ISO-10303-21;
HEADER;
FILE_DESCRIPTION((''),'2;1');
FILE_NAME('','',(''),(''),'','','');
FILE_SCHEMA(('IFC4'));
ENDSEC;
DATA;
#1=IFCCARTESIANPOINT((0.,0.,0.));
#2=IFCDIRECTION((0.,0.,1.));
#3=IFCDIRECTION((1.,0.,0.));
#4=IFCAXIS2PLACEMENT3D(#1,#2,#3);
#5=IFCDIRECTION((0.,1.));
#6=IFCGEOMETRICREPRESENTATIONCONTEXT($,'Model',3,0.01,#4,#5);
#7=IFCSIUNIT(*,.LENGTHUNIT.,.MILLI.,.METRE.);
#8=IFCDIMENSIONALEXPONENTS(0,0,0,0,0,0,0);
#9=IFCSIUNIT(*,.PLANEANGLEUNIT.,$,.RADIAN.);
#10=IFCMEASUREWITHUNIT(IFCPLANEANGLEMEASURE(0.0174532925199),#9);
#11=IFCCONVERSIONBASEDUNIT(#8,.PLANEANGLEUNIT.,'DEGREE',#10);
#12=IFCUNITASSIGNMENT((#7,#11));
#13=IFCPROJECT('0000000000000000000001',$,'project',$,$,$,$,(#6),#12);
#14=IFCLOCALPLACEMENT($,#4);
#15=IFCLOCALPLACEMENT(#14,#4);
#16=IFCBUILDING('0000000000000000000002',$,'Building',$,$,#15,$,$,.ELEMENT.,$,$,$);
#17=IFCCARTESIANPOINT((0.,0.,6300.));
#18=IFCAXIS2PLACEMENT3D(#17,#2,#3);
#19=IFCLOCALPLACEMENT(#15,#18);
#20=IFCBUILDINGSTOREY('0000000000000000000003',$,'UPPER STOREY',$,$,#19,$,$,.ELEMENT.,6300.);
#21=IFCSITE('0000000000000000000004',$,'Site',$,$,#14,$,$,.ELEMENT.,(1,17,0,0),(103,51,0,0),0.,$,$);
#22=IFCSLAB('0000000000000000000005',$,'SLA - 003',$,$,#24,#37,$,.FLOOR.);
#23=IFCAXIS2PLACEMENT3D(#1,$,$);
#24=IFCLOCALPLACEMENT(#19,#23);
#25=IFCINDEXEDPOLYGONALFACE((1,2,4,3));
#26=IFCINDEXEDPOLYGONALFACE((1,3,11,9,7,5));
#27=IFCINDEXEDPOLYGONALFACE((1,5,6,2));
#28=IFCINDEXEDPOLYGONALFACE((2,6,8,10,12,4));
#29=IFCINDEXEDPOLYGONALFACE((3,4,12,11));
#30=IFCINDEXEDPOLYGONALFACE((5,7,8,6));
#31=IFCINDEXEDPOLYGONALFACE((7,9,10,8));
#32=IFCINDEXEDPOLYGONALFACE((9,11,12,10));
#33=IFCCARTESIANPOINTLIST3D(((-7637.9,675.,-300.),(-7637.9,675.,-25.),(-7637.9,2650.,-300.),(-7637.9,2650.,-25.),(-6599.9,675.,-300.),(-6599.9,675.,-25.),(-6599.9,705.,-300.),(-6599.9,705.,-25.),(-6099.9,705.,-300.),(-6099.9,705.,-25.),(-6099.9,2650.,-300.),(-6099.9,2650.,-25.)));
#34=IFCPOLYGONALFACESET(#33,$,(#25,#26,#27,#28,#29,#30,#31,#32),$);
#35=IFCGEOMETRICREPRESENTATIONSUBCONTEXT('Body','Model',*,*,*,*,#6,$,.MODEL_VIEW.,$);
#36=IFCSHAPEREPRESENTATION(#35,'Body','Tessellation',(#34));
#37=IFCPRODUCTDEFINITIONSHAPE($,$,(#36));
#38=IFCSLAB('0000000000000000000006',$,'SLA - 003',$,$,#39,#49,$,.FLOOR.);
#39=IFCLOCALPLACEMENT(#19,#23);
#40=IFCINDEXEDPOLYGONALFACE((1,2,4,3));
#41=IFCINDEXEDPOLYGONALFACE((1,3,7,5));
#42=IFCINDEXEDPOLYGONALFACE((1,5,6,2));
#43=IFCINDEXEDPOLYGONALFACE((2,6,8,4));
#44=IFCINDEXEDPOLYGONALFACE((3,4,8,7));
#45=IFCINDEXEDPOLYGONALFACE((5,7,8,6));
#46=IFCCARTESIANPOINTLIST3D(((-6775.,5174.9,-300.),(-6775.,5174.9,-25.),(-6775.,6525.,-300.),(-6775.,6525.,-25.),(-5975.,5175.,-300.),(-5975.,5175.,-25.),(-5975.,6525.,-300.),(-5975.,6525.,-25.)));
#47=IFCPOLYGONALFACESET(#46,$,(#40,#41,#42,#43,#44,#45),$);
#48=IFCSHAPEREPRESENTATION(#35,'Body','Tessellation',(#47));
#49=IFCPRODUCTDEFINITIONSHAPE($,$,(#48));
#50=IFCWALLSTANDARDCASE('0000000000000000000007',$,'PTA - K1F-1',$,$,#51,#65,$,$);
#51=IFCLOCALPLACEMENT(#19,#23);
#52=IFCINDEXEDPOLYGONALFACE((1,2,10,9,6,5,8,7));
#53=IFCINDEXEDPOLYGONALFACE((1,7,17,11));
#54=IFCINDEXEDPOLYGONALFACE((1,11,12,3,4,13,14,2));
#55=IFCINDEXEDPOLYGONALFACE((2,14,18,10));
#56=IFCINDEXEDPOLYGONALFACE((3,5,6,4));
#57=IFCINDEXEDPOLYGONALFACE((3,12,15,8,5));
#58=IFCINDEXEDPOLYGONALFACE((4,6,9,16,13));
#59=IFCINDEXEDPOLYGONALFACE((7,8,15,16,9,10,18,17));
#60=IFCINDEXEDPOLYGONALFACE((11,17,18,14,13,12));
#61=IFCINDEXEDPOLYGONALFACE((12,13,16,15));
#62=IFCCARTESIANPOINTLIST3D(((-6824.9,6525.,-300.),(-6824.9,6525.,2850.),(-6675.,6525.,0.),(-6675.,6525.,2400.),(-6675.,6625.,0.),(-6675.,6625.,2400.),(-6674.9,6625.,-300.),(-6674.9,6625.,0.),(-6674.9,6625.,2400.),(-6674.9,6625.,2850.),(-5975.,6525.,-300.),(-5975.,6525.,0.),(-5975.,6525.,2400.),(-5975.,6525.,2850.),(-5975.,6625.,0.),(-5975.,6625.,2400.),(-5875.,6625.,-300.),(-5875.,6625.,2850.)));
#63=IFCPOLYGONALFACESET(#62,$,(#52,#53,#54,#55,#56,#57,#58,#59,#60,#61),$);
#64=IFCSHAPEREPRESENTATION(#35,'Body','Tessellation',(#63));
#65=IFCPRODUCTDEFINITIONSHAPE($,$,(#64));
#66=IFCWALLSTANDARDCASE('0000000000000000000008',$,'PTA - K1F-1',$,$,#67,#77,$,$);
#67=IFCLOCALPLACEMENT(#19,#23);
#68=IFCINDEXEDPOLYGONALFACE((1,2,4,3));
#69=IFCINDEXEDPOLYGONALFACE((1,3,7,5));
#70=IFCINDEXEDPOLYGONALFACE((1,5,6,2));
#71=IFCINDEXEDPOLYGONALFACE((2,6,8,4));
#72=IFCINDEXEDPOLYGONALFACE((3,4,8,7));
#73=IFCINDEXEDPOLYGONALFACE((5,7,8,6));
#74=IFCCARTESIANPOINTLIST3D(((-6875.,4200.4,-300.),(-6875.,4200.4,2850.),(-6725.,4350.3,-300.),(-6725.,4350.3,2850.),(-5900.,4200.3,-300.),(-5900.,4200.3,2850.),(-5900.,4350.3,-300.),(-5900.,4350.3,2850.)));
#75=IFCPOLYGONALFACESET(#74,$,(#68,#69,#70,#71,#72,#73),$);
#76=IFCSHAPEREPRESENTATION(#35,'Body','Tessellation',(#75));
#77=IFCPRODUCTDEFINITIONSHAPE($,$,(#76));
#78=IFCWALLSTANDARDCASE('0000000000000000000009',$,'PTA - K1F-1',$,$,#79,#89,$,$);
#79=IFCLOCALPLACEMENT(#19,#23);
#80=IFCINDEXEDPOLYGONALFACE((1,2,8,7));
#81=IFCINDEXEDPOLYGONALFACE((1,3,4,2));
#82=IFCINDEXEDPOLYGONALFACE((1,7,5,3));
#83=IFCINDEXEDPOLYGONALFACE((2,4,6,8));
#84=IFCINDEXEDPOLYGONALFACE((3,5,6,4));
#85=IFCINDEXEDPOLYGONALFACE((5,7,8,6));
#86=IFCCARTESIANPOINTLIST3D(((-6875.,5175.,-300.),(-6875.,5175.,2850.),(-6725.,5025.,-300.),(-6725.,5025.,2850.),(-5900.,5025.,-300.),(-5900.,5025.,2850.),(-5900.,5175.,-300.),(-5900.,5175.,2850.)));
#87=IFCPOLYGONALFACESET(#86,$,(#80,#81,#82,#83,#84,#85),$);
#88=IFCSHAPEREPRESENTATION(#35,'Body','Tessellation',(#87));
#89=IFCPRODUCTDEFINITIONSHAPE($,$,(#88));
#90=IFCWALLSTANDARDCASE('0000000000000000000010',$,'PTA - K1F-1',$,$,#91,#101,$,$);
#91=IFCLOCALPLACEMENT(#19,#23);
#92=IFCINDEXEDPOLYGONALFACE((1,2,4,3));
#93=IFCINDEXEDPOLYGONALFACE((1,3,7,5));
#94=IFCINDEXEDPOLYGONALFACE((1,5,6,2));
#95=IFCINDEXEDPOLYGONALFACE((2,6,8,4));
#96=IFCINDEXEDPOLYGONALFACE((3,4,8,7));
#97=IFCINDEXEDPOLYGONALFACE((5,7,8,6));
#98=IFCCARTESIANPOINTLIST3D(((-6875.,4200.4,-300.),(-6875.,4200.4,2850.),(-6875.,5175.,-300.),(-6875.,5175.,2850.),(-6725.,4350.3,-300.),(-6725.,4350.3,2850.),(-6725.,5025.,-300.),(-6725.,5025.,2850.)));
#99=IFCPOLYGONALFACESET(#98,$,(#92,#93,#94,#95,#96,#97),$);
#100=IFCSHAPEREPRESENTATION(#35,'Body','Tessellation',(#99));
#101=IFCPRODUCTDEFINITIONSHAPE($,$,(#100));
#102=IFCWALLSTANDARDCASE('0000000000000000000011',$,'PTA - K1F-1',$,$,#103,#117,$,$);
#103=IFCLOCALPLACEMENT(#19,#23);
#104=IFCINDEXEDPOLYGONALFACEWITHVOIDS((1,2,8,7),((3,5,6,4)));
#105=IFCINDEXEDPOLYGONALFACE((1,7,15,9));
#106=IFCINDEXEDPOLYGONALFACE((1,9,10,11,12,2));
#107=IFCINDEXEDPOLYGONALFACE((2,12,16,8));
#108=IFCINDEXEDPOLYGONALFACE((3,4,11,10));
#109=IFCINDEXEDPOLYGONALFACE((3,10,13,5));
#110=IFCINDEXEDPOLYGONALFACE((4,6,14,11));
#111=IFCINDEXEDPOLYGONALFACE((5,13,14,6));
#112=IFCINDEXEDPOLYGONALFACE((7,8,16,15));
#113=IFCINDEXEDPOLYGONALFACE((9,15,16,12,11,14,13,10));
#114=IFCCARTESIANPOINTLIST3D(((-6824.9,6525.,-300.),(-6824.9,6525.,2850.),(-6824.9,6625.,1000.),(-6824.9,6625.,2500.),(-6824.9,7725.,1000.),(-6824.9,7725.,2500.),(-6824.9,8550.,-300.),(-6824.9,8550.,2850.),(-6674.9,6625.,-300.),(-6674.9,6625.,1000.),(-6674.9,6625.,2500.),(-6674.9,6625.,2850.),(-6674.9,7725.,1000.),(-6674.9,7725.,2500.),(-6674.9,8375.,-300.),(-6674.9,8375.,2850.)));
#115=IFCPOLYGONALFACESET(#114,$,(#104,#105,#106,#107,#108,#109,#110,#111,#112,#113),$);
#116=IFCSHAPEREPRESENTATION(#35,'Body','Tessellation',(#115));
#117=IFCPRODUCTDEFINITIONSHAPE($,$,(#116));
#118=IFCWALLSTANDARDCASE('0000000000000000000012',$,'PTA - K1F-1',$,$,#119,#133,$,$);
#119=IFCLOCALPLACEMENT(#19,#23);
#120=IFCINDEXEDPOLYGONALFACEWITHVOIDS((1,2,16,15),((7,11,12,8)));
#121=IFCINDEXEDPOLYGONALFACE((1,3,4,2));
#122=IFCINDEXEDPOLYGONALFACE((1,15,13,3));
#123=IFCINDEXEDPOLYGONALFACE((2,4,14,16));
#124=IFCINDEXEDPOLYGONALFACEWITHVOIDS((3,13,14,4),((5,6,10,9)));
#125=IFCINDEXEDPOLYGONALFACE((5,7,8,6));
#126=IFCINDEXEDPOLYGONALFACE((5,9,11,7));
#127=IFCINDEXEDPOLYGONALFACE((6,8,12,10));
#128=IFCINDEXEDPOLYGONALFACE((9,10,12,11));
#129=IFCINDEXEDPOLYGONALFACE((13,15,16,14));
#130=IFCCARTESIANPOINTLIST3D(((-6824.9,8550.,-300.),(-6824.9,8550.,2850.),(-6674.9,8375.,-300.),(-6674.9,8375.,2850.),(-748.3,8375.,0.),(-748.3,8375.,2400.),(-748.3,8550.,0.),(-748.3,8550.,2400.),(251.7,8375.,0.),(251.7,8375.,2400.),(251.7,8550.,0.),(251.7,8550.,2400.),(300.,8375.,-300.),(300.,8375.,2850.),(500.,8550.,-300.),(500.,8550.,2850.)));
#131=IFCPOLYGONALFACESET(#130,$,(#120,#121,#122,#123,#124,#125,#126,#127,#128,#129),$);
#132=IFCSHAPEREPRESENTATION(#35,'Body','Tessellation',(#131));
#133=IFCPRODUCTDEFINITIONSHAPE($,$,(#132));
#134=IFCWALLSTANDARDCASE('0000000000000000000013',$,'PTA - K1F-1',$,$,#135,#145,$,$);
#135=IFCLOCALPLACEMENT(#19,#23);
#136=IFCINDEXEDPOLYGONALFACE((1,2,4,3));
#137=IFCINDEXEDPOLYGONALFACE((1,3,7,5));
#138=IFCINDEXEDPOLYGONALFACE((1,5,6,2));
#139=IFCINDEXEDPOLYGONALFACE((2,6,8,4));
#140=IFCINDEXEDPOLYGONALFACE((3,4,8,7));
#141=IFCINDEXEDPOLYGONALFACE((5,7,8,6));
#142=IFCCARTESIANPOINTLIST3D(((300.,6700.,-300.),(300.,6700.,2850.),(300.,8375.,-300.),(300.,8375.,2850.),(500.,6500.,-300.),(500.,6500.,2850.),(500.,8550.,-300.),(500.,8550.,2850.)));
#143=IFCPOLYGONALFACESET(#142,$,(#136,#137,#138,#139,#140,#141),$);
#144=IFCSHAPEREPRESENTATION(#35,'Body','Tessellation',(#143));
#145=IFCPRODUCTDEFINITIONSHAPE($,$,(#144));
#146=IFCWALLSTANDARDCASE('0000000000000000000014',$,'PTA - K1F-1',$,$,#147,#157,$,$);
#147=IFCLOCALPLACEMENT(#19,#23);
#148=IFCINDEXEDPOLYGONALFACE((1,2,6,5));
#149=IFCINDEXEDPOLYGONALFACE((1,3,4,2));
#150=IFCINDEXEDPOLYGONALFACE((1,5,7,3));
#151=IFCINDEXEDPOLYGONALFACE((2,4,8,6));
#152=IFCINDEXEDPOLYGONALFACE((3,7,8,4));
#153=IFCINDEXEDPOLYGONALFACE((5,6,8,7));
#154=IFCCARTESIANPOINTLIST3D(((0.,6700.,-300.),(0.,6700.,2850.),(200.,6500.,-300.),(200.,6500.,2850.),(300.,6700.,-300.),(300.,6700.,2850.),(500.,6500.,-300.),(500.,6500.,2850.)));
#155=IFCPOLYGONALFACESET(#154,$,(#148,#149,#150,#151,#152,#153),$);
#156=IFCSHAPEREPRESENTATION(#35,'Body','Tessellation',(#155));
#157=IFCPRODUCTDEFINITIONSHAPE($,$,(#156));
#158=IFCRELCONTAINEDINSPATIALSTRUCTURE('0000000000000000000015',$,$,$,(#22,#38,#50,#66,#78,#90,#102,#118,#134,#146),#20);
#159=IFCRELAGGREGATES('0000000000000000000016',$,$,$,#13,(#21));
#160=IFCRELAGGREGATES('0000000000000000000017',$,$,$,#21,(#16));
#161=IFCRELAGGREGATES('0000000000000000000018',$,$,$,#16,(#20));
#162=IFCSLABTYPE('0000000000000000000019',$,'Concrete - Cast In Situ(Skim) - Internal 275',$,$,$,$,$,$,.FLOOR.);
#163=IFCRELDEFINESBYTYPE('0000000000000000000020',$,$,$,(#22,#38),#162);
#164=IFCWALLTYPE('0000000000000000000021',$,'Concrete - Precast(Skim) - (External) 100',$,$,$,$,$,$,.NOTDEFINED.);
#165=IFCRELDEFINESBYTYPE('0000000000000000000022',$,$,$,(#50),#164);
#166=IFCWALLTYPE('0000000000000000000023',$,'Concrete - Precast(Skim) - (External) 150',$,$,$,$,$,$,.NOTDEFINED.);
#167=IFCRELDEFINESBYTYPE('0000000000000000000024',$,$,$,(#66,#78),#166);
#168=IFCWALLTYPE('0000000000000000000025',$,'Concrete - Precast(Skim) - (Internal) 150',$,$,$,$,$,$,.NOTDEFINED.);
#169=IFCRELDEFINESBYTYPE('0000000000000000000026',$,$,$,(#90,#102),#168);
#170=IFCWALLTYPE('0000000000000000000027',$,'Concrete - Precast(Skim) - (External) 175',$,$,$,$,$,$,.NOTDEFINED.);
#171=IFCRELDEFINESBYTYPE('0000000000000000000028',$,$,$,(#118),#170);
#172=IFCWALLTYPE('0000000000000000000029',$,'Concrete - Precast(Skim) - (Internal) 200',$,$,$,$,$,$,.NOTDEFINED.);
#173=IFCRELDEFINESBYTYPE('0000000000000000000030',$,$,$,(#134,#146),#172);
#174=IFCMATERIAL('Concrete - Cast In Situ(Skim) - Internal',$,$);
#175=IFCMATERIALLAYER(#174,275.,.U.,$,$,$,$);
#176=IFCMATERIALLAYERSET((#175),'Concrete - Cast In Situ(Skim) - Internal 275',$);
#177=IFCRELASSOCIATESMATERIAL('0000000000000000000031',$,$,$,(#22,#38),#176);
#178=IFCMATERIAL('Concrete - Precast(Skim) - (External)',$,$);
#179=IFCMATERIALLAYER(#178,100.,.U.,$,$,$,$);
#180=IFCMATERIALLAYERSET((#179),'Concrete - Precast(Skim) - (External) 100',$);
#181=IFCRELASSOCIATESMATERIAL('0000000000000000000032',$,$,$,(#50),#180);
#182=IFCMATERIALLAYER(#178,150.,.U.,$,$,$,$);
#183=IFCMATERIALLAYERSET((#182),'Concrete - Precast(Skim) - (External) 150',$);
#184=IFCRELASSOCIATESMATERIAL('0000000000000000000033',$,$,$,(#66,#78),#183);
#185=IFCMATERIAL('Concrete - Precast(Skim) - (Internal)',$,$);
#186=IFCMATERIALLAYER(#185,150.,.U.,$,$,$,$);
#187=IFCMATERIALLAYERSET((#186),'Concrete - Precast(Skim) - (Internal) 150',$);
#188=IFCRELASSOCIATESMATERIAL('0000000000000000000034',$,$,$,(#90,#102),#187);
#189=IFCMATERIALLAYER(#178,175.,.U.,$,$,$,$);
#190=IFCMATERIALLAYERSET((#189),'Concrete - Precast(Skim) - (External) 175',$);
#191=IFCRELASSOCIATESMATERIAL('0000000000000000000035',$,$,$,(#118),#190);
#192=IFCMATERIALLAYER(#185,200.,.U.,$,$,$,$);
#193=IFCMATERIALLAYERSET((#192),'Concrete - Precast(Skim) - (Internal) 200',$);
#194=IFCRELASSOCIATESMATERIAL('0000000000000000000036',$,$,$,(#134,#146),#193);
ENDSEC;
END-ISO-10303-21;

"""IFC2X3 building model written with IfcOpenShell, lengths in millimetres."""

from ifc_helpers import new_model, entity, si_unit, converted_unit, direction, frame, origin_with_axes, origin_2d_with_axis, place, context, subcontext, project, spatial, polyline, rectangle, outline, extrude, material, layer, layer_set, layer_usage, type_object, element, save


model = new_model("IFC2X3")

# Units and contexts
model_context = context("Model", 3, precision=0.01, world=origin_with_axes(), true_north=direction((0.0, 1.0)))
body_context = subcontext(model_context, "Body", "Model", "MODEL_VIEW")
ifc_project = project(units=[si_unit("LENGTHUNIT", "METRE", prefix="MILLI"), converted_unit("PLANEANGLEUNIT", "DEGREE", entity("IfcPlaneAngleMeasure", 0.0174532925199), si_unit("PLANEANGLEUNIT", "RADIAN"), dimensions=[0, 0, 0, 0, 0, 0, 0])], contexts=[model_context])

# Site, building, storey
site_placement = place(None, origin_with_axes())
site = spatial("IfcSite", under=ifc_project, at=site_placement, Name="Site", CompositionType="ELEMENT", RefLatitude=(1, 17, 0, 0), RefLongitude=(103, 51, 0, 0), RefElevation=0.0)
building_placement = place(site_placement, origin_with_axes())
building = spatial("IfcBuilding", under=site, at=building_placement, Name="Building", CompositionType="ELEMENT")
storey_placement = place(building_placement, frame((0.0, 0.0, 6300.0), z_axis=(0.0, 0.0, 1.0), x_axis=(1.0, 0.0, 0.0)))
storey = spatial("IfcBuildingStorey", under=building, at=storey_placement, Name="UPPER STOREY", CompositionType="ELEMENT", Elevation=6300.0)

# Slabs
ifc_material_1 = material(Name="Concrete - Cast In Situ(Skim) - Internal")
ifc_layer_1 = layer(ifc_material_1, 275.0, ventilated="UNKNOWN")
ifc_layer_set_1 = layer_set([ifc_layer_1], Name="Concrete - Cast In Situ(Skim) - Internal 275")
ifc_layer_usage_1 = layer_usage(ifc_layer_set_1, "AXIS3", "NEGATIVE", 275.0)
slab_type = type_object("IfcSlabType", Name="Concrete - Cast In Situ(Skim) - Internal 275", PredefinedType="FLOOR")
slab_1_placement = place(storey_placement, frame((-6099.9, 2650.0, -25.0), z_axis=(0.0, 0.0, 1.0), x_axis=(1.0, 0.0, 0.0)))
element("IfcSlab", 1, at=slab_1_placement, inside=storey, type_object=slab_type, material=ifc_layer_usage_1, Name="SLA - 003", PredefinedType="FLOOR", context=body_context, shape_type="SweptSolid", body=[
    extrude(outline(polyline([(0.0, 0.0), (-1538.0, 0.0), (-1538.0, -1975.0), (-500.0, -1975.0), (-500.0, -1945.0), (0.0, -1945.0), (0.0, 0.0)])), frame((0.0, 0.0, -275.0), z_axis=(0.0, 0.0, 1.0), x_axis=(1.0, 0.0, 0.0)), (0.0, 0.0, 1.0), 275.0),
])
ifc_layer_usage_2 = layer_usage(ifc_layer_set_1, "AXIS3", "NEGATIVE", 275.0)
slab_2_placement = place(storey_placement, frame((-6775.0, 6525.0, -25.0), z_axis=(0.0, 0.0, 1.0), x_axis=(1.0, 0.0, 0.0)))
element("IfcSlab", 2, at=slab_2_placement, inside=storey, type_object=slab_type, material=ifc_layer_usage_2, Name="SLA - 003", PredefinedType="FLOOR", context=body_context, shape_type="SweptSolid", body=[
    extrude(outline(polyline([(0.0, 0.0), (0.0, -1350.1), (800.0, -1350.0), (800.0, 0.0), (0.0, 0.0)])), frame((0.0, 0.0, -275.0), z_axis=(0.0, 0.0, 1.0), x_axis=(1.0, 0.0, 0.0)), (0.0, 0.0, 1.0), 275.0),
])

# Wall, opening
ifc_material_2 = material(Name="Concrete - Precast(Skim) - (External)")
ifc_layer_2 = layer(ifc_material_2, 100.0, ventilated="UNKNOWN")
ifc_layer_set_2 = layer_set([ifc_layer_2], Name="Concrete - Precast(Skim) - (External) 100")
ifc_layer_usage_3 = layer_usage(ifc_layer_set_2, "AXIS2", "NEGATIVE", 0.0)
wall_type_1 = type_object("IfcWallType", Name="Concrete - Precast(Skim) - (External) 100", PredefinedType="NOTDEFINED")
wall_1_placement = place(storey_placement, frame((-6824.9, 6625.0, -300.0), z_axis=(0.0, 0.0, 1.0), x_axis=(1.0, 0.0, 0.0)))
wall_1 = element("IfcWallStandardCase", 3, at=wall_1_placement, inside=storey, type_object=wall_type_1, material=ifc_layer_usage_3, Name="PTA - K1F-1", context=body_context, shape_type="SweptSolid", body=[
    extrude(outline(polyline([(0.0, -100.0), (849.9, -100.0), (949.9, 0.0), (150.0, 0.0), (0.0, -100.0)])), origin_with_axes(), (0.0, 0.0, 1.0), 3150.0),
])
opening_1_placement = place(wall_1_placement, frame((499.9, 0.0, 300.0), z_axis=(0.0, 0.0, 1.0), x_axis=(1.0, 0.0, 0.0)))
element("IfcOpeningElement", 4, at=opening_1_placement, cuts=wall_1, context=body_context, shape_type="SweptSolid", body=[
    extrude(rectangle(XDim=700.0, YDim=2400.0, at=origin_2d_with_axis()), frame((0.0, 100.0, 1200.0), z_axis=(0.0, -1.0, 0.0), x_axis=(-1.0, 0.0, 0.0)), (0.0, 0.0, 1.0), 300.0),
])

# Walls
ifc_layer_3 = layer(ifc_material_2, 150.0, ventilated="UNKNOWN")
ifc_layer_set_3 = layer_set([ifc_layer_3], Name="Concrete - Precast(Skim) - (External) 150")
ifc_layer_usage_4 = layer_usage(ifc_layer_set_3, "AXIS2", "POSITIVE", 0.0)
wall_type_2 = type_object("IfcWallType", Name="Concrete - Precast(Skim) - (External) 150", PredefinedType="NOTDEFINED")
wall_2_placement = place(storey_placement, frame((-6875.0, 4200.4, -300.0), z_axis=(0.0, 0.0, 1.0), x_axis=(1.0, -0.000039, 0.0)))
element("IfcWallStandardCase", 5, at=wall_2_placement, inside=storey, type_object=wall_type_2, material=ifc_layer_usage_4, Name="PTA - K1F-1", context=body_context, shape_type="SweptSolid", body=[
    extrude(outline(polyline([(0.0, 0.0), (975.0, 0.0), (975.0, 150.0), (150.0, 150.0), (0.0, 0.0)])), origin_with_axes(), (0.0, 0.0, 1.0), 3150.0),
])
ifc_layer_usage_5 = layer_usage(ifc_layer_set_3, "AXIS2", "NEGATIVE", 0.0)
wall_3_placement = place(storey_placement, frame((-6875.0, 5175.0, -300.0), z_axis=(0.0, 0.0, 1.0), x_axis=(1.0, -0.000039, 0.0)))
element("IfcWallStandardCase", 6, at=wall_3_placement, inside=storey, type_object=wall_type_2, material=ifc_layer_usage_5, Name="PTA - K1F-1", context=body_context, shape_type="SweptSolid", body=[
    extrude(outline(polyline([(150.0, -150.0), (975.0, -150.0), (975.0, 0.0), (0.0, 0.0), (150.0, -150.0)])), origin_with_axes(), (0.0, 0.0, 1.0), 3150.0),
])
ifc_material_3 = material(Name="Concrete - Precast(Skim) - (Internal)")
ifc_layer_4 = layer(ifc_material_3, 150.0, ventilated="UNKNOWN")
ifc_layer_set_4 = layer_set([ifc_layer_4], Name="Concrete - Precast(Skim) - (Internal) 150")
ifc_layer_usage_6 = layer_usage(ifc_layer_set_4, "AXIS2", "NEGATIVE", 0.0)
wall_type_3 = type_object("IfcWallType", Name="Concrete - Precast(Skim) - (Internal) 150", PredefinedType="NOTDEFINED")
wall_4_placement = place(storey_placement, frame((-6875.0, 4200.4, -300.0), z_axis=(0.0, 0.0, 1.0), x_axis=(0.0, 1.0, 0.0)))
element("IfcWallStandardCase", 7, at=wall_4_placement, inside=storey, type_object=wall_type_3, material=ifc_layer_usage_6, Name="PTA - K1F-1", context=body_context, shape_type="SweptSolid", body=[
    extrude(outline(polyline([(150.0, -150.0), (824.6, -150.0), (974.6, 0.0), (0.0, 0.0), (150.0, -150.0)])), origin_with_axes(), (0.0, 0.0, 1.0), 3150.0),
])

# Walls, openings
ifc_layer_usage_7 = layer_usage(ifc_layer_set_4, "AXIS2", "NEGATIVE", 0.0)
wall_5_placement = place(storey_placement, frame((-6824.9, 6625.0, -300.0), z_axis=(0.0, 0.0, 1.0), x_axis=(0.0, 1.0, 0.0)))
wall_5 = element("IfcWallStandardCase", 8, at=wall_5_placement, inside=storey, type_object=wall_type_3, material=ifc_layer_usage_7, Name="PTA - K1F-1", context=body_context, shape_type="SweptSolid", body=[
    extrude(outline(polyline([(0.0, -150.0), (1750.0, -150.0), (1925.0, 0.0), (-100.0, 0.0), (0.0, -150.0)])), origin_with_axes(), (0.0, 0.0, 1.0), 3150.0),
])
opening_2_placement = place(wall_5_placement, frame((550.0, 0.0, 1300.0), z_axis=(0.0, 0.0, 1.0), x_axis=(1.0, 0.0, 0.0)))
element("IfcOpeningElement", 9, at=opening_2_placement, cuts=wall_5, context=body_context, shape_type="SweptSolid", body=[
    extrude(rectangle(XDim=1100.0, YDim=1500.0, at=origin_2d_with_axis()), frame((0.0, -150.0, 750.0), z_axis=(0.0, -1.0, 0.0), x_axis=(-1.0, 0.0, 0.0)), (0.0, 0.0, -1.0), 450.0),
])
ifc_layer_5 = layer(ifc_material_2, 175.0, ventilated="UNKNOWN")
ifc_layer_set_5 = layer_set([ifc_layer_5], Name="Concrete - Precast(Skim) - (External) 175")
ifc_layer_usage_8 = layer_usage(ifc_layer_set_5, "AXIS2", "NEGATIVE", 0.0)
wall_type_4 = type_object("IfcWallType", Name="Concrete - Precast(Skim) - (External) 175", PredefinedType="NOTDEFINED")
wall_6_placement = place(storey_placement, frame((-6824.9, 8550.0, -300.0), z_axis=(0.0, 0.0, 1.0), x_axis=(1.0, 0.000002, 0.0)))
wall_6 = element("IfcWallStandardCase", 10, at=wall_6_placement, inside=storey, type_object=wall_type_4, material=ifc_layer_usage_8, Name="PTA - K1F-1", context=body_context, shape_type="SweptSolid", body=[
    extrude(outline(polyline([(150.0, -175.0), (7124.9, -175.0), (7324.9, 0.0), (0.0, 0.0), (150.0, -175.0)])), origin_with_axes(), (0.0, 0.0, 1.0), 3150.0),
])
opening_3_placement = place(wall_6_placement, frame((6576.6, 0.0, 300.0), z_axis=(0.0, 0.0, 1.0), x_axis=(1.0, 0.0, 0.0)))
element("IfcOpeningElement", 11, at=opening_3_placement, cuts=wall_6, context=body_context, shape_type="SweptSolid", body=[
    extrude(rectangle(XDim=1000.0, YDim=2400.0, at=origin_2d_with_axis()), frame((0.0, -175.0, 1200.0), z_axis=(-0.000002, -1.0, 0.0), x_axis=(1.0, -0.000002, 0.0)), (0.0, 0.0, -1.0), 525.0),
])

# Walls
ifc_layer_6 = layer(ifc_material_3, 200.0, ventilated="UNKNOWN")
ifc_layer_set_6 = layer_set([ifc_layer_6], Name="Concrete - Precast(Skim) - (Internal) 200")
ifc_layer_usage_9 = layer_usage(ifc_layer_set_6, "AXIS2", "NEGATIVE", 0.0)
wall_type_5 = type_object("IfcWallType", Name="Concrete - Precast(Skim) - (Internal) 200", PredefinedType="NOTDEFINED")
wall_7_placement = place(storey_placement, frame((300.0, 6700.0, -300.0), z_axis=(0.0, 0.0, 1.0), x_axis=(-0.000007, 1.0, 0.0)))
element("IfcWallStandardCase", 12, at=wall_7_placement, inside=storey, type_object=wall_type_5, material=ifc_layer_usage_9, Name="PTA - K1F-1", context=body_context, shape_type="SweptSolid", body=[
    extrude(outline(polyline([(-200.0, -200.0), (1850.0, -200.0), (1675.0, 0.0), (0.0, 0.0), (-200.0, -200.0)])), origin_with_axes(), (0.0, 0.0, 1.0), 3150.0),
])
ifc_layer_usage_10 = layer_usage(ifc_layer_set_6, "AXIS2", "NEGATIVE", 0.0)
wall_8_placement = place(storey_placement, frame((0.0, 6700.0, -300.0), z_axis=(0.0, 0.0, 1.0), x_axis=(1.0, 0.000097, 0.0)))
element("IfcWallStandardCase", 13, at=wall_8_placement, inside=storey, type_object=wall_type_5, material=ifc_layer_usage_10, Name="PTA - K1F-1", context=body_context, shape_type="SweptSolid", body=[
    extrude(outline(polyline([(200.0, -200.0), (500.0, -200.0), (300.0, 0.0), (0.0, 0.0), (200.0, -200.0)])), origin_with_axes(), (0.0, 0.0, 1.0), 3150.0),
])

save(model, "model.ifc")
